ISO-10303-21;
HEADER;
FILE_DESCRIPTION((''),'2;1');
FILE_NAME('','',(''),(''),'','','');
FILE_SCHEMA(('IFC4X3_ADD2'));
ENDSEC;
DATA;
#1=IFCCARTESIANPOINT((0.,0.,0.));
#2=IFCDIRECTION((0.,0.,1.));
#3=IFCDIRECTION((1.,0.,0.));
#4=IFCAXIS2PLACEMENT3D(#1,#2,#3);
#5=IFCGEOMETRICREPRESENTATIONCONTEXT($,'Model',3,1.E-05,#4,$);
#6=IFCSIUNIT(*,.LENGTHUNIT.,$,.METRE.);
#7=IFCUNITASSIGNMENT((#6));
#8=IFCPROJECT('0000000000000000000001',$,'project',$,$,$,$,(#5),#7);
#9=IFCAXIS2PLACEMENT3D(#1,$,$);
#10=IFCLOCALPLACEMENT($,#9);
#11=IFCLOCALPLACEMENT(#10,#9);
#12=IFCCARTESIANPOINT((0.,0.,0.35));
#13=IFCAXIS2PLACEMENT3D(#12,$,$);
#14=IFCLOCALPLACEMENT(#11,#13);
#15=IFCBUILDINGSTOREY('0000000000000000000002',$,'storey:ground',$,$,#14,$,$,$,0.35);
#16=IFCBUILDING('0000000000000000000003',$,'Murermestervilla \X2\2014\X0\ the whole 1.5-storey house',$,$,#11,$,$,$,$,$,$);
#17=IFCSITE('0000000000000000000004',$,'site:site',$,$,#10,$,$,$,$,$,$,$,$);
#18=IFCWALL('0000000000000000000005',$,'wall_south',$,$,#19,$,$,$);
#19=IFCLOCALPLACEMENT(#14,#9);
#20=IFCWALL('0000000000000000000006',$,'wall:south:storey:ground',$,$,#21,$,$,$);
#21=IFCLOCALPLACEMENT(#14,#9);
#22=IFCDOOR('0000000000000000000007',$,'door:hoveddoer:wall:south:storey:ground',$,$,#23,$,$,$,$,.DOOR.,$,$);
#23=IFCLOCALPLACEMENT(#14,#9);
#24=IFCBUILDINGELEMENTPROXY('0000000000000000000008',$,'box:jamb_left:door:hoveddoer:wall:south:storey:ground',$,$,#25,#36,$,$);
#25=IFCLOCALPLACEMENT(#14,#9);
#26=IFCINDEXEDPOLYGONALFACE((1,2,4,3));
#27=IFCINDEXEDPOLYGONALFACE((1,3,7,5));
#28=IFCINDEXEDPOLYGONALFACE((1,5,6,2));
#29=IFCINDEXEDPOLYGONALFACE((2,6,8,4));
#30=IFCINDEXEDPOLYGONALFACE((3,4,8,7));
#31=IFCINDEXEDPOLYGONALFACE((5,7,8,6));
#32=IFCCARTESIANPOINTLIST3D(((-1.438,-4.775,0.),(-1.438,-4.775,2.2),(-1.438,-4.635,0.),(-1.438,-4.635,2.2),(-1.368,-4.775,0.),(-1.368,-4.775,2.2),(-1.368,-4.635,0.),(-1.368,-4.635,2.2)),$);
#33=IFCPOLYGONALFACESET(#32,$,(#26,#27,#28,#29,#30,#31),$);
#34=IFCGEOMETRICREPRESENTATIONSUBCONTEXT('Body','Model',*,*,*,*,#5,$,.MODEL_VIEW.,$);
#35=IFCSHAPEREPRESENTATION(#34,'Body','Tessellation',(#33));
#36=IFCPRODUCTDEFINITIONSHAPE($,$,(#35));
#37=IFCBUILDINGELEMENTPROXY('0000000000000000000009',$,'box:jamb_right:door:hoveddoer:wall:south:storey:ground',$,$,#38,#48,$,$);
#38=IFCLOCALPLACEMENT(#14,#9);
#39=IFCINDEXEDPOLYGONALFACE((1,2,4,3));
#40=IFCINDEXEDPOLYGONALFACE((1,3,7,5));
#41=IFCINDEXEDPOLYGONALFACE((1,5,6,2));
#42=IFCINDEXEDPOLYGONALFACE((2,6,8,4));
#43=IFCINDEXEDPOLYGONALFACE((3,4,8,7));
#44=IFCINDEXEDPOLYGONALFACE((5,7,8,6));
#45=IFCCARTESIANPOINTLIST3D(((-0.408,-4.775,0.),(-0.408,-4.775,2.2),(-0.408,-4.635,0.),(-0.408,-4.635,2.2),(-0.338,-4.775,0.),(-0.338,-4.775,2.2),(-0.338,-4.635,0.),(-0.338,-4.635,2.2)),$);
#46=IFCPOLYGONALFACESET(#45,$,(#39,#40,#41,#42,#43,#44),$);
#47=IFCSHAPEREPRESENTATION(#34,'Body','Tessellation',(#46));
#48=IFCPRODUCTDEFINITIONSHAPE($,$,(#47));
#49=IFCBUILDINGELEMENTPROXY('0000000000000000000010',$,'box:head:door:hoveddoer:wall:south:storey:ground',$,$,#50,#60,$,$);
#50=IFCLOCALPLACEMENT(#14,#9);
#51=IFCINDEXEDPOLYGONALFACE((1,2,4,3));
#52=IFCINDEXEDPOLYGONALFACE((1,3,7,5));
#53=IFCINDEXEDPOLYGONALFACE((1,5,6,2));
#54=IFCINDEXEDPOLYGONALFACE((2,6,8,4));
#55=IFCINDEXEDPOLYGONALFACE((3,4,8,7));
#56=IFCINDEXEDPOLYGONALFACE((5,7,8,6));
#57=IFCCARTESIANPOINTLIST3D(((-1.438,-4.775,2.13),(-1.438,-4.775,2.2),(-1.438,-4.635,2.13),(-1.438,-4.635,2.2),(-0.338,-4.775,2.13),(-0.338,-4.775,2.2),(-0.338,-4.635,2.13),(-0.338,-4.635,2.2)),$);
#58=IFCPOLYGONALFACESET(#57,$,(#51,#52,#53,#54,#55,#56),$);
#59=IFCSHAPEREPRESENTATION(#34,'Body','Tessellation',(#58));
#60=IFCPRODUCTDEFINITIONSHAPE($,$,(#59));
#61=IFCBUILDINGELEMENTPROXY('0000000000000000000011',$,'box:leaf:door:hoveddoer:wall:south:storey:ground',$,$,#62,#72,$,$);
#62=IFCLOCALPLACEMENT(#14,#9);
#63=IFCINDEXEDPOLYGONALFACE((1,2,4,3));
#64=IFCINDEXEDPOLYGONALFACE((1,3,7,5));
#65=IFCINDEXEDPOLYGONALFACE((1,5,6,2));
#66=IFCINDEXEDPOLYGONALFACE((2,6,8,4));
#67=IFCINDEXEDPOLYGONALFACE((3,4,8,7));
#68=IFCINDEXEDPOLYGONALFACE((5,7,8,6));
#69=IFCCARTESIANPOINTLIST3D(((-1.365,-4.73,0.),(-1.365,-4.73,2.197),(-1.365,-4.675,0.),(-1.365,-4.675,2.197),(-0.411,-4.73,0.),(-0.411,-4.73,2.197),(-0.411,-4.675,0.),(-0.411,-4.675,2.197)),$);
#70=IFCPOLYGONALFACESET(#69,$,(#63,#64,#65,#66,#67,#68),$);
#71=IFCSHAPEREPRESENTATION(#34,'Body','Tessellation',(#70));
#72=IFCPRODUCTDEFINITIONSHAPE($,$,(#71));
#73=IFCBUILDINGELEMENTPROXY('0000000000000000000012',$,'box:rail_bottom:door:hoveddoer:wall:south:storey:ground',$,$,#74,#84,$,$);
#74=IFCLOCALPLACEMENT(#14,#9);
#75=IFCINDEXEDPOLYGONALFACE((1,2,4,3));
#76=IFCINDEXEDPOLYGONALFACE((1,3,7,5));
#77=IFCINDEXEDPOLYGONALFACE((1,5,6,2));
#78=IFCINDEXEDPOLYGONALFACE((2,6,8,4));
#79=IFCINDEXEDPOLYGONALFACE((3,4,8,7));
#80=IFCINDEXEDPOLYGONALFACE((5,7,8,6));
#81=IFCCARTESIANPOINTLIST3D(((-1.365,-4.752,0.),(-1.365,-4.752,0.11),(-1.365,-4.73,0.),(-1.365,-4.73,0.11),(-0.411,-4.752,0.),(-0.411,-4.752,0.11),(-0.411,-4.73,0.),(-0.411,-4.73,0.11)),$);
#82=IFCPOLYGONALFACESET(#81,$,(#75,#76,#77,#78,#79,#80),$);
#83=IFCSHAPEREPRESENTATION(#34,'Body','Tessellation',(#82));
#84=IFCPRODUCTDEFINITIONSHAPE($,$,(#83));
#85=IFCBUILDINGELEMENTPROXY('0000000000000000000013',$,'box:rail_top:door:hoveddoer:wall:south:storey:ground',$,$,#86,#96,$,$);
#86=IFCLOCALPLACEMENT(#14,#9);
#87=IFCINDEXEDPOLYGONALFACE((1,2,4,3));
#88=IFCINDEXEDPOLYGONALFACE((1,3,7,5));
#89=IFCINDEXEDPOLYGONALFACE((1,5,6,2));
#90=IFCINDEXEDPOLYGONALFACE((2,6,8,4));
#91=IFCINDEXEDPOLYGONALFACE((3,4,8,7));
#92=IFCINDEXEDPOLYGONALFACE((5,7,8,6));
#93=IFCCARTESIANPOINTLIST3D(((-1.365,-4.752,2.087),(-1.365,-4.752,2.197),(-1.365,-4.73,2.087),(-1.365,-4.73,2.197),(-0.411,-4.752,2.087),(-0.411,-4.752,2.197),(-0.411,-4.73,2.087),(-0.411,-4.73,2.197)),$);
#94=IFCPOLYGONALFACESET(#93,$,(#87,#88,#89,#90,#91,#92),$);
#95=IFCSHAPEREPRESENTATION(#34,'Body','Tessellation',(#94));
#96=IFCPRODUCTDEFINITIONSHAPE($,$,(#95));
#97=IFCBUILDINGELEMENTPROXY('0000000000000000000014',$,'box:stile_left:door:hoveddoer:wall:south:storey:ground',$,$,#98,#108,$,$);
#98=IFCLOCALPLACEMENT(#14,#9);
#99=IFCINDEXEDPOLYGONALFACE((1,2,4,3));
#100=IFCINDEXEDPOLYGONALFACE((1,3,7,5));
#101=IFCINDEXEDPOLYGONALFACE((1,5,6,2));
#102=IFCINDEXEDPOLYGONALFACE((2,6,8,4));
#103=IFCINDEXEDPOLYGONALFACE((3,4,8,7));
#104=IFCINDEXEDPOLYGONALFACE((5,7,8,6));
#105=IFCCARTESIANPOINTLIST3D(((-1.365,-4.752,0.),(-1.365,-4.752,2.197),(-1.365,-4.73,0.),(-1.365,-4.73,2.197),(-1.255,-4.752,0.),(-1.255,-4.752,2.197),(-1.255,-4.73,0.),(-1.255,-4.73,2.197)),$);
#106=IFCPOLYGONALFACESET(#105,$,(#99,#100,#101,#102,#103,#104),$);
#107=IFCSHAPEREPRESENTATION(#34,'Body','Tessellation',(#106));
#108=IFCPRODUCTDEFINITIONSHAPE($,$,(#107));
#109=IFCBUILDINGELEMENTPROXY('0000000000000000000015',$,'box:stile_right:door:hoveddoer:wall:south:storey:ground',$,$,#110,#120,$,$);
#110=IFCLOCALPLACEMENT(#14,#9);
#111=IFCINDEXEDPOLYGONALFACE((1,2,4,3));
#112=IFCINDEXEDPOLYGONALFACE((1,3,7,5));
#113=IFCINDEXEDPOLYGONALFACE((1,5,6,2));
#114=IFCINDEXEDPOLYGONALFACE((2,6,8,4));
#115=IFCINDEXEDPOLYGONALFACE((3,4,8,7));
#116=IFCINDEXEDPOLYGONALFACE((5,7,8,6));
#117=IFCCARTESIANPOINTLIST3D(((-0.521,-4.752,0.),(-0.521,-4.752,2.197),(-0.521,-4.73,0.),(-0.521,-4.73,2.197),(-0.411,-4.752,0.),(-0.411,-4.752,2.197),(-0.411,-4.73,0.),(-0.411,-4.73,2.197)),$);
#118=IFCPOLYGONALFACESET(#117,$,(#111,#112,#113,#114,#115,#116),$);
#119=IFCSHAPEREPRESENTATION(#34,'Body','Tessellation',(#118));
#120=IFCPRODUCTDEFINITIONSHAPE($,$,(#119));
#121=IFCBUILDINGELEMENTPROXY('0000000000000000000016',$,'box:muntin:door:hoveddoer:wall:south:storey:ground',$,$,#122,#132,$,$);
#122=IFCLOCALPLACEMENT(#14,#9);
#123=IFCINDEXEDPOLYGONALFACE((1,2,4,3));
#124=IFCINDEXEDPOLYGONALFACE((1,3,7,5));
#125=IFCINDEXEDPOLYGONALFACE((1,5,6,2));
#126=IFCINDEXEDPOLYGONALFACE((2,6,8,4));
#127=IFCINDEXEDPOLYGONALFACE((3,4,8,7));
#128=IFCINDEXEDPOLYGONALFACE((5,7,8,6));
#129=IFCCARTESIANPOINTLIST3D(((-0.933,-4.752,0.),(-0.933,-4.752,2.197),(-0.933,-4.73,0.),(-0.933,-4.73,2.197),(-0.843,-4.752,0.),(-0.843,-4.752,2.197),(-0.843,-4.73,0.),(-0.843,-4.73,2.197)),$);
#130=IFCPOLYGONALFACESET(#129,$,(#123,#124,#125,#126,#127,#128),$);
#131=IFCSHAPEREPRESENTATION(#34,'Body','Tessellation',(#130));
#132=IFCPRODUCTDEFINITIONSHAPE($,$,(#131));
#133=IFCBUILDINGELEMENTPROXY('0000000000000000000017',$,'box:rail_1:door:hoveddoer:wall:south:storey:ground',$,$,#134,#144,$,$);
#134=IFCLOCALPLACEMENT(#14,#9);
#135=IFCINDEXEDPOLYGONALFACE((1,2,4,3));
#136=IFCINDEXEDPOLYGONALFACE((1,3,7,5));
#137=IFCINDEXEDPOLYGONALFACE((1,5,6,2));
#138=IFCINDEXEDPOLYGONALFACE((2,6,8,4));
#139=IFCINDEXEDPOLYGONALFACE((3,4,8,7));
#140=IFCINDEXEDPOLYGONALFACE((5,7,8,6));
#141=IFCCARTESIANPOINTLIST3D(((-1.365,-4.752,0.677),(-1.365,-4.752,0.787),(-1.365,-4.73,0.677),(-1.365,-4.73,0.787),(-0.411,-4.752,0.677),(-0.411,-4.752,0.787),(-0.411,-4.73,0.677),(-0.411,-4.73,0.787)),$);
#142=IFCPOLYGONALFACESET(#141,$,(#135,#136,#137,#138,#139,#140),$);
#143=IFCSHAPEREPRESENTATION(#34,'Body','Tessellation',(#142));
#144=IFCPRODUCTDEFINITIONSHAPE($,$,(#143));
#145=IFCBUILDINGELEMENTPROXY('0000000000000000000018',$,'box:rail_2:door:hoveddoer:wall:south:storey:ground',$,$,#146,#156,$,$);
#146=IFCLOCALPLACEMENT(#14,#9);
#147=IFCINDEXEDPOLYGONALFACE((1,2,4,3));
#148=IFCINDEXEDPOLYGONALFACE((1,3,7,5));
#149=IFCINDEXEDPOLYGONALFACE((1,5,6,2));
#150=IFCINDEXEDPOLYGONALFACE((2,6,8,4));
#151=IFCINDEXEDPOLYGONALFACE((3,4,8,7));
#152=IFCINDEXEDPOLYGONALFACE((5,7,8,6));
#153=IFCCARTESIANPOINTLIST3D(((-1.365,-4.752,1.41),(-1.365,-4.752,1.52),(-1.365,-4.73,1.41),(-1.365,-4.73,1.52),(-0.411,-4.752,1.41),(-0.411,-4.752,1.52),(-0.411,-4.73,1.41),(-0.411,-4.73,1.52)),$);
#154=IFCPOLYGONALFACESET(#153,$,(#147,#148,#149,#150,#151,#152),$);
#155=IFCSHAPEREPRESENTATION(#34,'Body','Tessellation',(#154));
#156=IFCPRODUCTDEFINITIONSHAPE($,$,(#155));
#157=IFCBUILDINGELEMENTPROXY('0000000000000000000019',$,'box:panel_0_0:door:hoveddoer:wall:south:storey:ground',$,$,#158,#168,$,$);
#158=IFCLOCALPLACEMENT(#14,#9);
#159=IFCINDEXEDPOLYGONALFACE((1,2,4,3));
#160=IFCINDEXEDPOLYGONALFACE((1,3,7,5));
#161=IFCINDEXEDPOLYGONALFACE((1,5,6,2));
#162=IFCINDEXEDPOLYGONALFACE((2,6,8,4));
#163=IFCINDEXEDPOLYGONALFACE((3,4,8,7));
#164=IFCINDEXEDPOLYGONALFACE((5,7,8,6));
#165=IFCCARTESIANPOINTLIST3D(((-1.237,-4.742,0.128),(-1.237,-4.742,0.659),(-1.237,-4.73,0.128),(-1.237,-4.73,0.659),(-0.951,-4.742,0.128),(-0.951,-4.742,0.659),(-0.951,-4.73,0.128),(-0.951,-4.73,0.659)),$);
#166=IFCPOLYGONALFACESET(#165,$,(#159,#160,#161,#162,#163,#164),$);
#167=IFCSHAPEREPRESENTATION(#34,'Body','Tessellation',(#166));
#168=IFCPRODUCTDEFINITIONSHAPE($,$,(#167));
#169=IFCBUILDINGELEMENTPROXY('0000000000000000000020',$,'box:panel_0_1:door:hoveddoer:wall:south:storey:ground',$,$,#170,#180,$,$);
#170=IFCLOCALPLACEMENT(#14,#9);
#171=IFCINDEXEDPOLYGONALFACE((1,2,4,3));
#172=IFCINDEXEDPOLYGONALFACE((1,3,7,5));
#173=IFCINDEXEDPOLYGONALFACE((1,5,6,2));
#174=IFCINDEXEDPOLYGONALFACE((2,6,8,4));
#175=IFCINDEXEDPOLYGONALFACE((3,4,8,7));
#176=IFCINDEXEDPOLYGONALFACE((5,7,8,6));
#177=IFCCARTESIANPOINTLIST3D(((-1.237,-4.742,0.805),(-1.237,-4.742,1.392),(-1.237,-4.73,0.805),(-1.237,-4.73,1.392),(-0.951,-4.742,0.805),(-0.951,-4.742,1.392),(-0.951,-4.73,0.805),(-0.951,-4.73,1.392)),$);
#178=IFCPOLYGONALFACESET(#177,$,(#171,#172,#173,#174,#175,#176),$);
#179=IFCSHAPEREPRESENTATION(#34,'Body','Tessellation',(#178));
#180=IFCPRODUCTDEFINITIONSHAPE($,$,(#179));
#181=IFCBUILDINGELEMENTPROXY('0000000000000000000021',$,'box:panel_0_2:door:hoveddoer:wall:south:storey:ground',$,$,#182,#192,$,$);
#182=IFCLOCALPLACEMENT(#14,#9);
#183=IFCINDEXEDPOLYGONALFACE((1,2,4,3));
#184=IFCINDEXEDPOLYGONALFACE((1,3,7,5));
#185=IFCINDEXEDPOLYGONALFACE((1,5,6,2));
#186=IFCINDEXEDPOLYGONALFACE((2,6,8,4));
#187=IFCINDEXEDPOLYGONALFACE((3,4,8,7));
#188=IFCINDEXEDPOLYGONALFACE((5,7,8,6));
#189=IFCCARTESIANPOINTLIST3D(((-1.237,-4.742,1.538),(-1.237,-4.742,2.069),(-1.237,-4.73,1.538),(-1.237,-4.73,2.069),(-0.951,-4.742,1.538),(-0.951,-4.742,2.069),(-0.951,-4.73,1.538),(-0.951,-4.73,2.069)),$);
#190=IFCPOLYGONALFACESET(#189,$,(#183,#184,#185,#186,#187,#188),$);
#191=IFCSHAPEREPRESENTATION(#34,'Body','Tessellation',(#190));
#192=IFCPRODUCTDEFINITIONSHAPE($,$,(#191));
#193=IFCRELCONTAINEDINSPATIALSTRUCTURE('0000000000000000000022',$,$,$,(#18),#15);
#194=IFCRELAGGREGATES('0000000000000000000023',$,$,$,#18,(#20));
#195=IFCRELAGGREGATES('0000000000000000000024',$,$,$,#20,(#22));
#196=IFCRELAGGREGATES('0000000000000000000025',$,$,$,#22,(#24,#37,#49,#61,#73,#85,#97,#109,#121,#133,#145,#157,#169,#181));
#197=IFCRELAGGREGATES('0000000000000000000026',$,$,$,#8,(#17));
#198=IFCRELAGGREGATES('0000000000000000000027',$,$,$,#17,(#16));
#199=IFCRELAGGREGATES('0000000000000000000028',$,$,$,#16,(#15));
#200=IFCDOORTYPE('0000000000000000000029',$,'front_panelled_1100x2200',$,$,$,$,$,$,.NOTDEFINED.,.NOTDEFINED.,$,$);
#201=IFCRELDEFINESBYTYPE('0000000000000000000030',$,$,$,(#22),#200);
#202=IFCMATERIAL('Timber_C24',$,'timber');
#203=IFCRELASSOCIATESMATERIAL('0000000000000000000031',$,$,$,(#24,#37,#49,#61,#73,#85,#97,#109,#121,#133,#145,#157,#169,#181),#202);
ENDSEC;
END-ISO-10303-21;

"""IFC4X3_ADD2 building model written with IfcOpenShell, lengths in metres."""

from ifc_helpers import new_model, si_unit, frame, origin, origin_with_axes, place, context, subcontext, project, spatial, rectangle, extrude, source, transform, mapped, material, type_object, element, aggregate, save


model = new_model("IFC4X3_ADD2")

# Units and contexts
model_context = context("Model", 3, precision=1e-05, world=origin_with_axes())
body_context = subcontext(model_context, "Body", "Model", "MODEL_VIEW")
ifc_project = project(units=[si_unit("LENGTHUNIT", "METRE")], contexts=[model_context])

# Site, building, storey
placement = place(None, origin())
site = spatial("IfcSite", under=ifc_project, at=placement, Name="site:site")
building_placement = place(placement, origin())
building = spatial("IfcBuilding", under=site, at=building_placement, Name="Murermestervilla — the whole 1.5-storey house")
storey_placement = place(building_placement, frame((0.0, 0.0, 0.35)))
storey = spatial("IfcBuildingStorey", under=building, at=storey_placement, Name="storey:ground", Elevation=0.35)

# Walls, door, building element proxies
wall_1_placement = place(storey_placement, origin())
wall_1 = element("IfcWall", 1, at=wall_1_placement, inside=storey, Name="wall_south")
wall_2_placement = place(wall_1_placement, frame((0.0, 0.0, -0.35)))
wall_2 = element("IfcWall", 2, at=wall_2_placement, Name="wall:south:storey:ground")
aggregate(wall_1, [wall_2])
door_type = type_object("IfcDoorType", Name="front_panelled_1100x2200", OperationType="NOTDEFINED", PredefinedType="NOTDEFINED")
door_placement = place(None, frame((-0.888, -4.828, 0.35)))
door = element("IfcDoor", 3, at=door_placement, type_object=door_type, Name="door:hoveddoer:wall:south:storey:ground", PredefinedType="DOOR")
aggregate(wall_2, [door])
ifc_material_1 = material(Name="Timber_C24", Category="timber")
shared_shape_1 = source(origin(), body_context, "Body", "SweptSolid", [
    extrude(rectangle(XDim=0.07, YDim=0.14), frame((0.0, 0.0, -1.1)), (0.0, 0.0, 1.0), 2.2),
])
proxy_1_placement = place(None, frame((-1.403, -4.705, 1.45)))
proxy_1 = element("IfcBuildingElementProxy", 4, at=proxy_1_placement, material=ifc_material_1, Name="box:jamb_left:door:hoveddoer:wall:south:storey:ground", context=body_context, shape_type="MappedRepresentation", body=[
    mapped(shared_shape_1, transform((0.0, 0.0, 0.0))),
])
shared_shape_2 = source(origin(), body_context, "Body", "SweptSolid", [
    extrude(rectangle(XDim=0.07, YDim=0.14), frame((0.0, 0.0, -1.1)), (0.0, 0.0, 1.0), 2.2),
])
proxy_2_placement = place(None, frame((-0.373, -4.705, 1.45)))
proxy_2 = element("IfcBuildingElementProxy", 5, at=proxy_2_placement, material=ifc_material_1, Name="box:jamb_right:door:hoveddoer:wall:south:storey:ground", context=body_context, shape_type="MappedRepresentation", body=[
    mapped(shared_shape_2, transform((0.0, 0.0, 0.0))),
])
shared_shape_3 = source(origin(), body_context, "Body", "SweptSolid", [
    extrude(rectangle(XDim=1.1, YDim=0.14), frame((0.0, 0.0, -0.035)), (0.0, 0.0, 1.0), 0.07),
])
proxy_3_placement = place(None, frame((-0.888, -4.705, 2.515)))
proxy_3 = element("IfcBuildingElementProxy", 6, at=proxy_3_placement, material=ifc_material_1, Name="box:head:door:hoveddoer:wall:south:storey:ground", context=body_context, shape_type="MappedRepresentation", body=[
    mapped(shared_shape_3, transform((0.0, 0.0, 0.0))),
])
shared_shape_4 = source(origin(), body_context, "Body", "SweptSolid", [
    extrude(rectangle(XDim=0.954, YDim=0.055), frame((0.0, 0.0, -1.0985)), (0.0, 0.0, 1.0), 2.197),
])
proxy_4_placement = place(None, frame((-0.888, -4.7025, 1.4485)))
proxy_4 = element("IfcBuildingElementProxy", 7, at=proxy_4_placement, material=ifc_material_1, Name="box:leaf:door:hoveddoer:wall:south:storey:ground", context=body_context, shape_type="MappedRepresentation", body=[
    mapped(shared_shape_4, transform((0.0, 0.0, 0.0))),
])
shared_shape_5 = source(origin(), body_context, "Body", "SweptSolid", [
    extrude(rectangle(XDim=0.954, YDim=0.022), frame((0.0, 0.0, -0.055)), (0.0, 0.0, 1.0), 0.11),
])
proxy_5_placement = place(None, frame((-0.888, -4.741, 0.405)))
proxy_5 = element("IfcBuildingElementProxy", 8, at=proxy_5_placement, material=ifc_material_1, Name="box:rail_bottom:door:hoveddoer:wall:south:storey:ground", context=body_context, shape_type="MappedRepresentation", body=[
    mapped(shared_shape_5, transform((0.0, 0.0, 0.0))),
])
shared_shape_6 = source(origin(), body_context, "Body", "SweptSolid", [
    extrude(rectangle(XDim=0.954, YDim=0.022), frame((0.0, 0.0, -0.055)), (0.0, 0.0, 1.0), 0.11),
])
proxy_6_placement = place(None, frame((-0.888, -4.741, 2.492)))
proxy_6 = element("IfcBuildingElementProxy", 9, at=proxy_6_placement, material=ifc_material_1, Name="box:rail_top:door:hoveddoer:wall:south:storey:ground", context=body_context, shape_type="MappedRepresentation", body=[
    mapped(shared_shape_6, transform((0.0, 0.0, 0.0))),
])
shared_shape_7 = source(origin(), body_context, "Body", "SweptSolid", [
    extrude(rectangle(XDim=0.11, YDim=0.022), frame((0.0, 0.0, -1.0985)), (0.0, 0.0, 1.0), 2.197),
])
proxy_7_placement = place(None, frame((-1.31, -4.741, 1.4485)))
proxy_7 = element("IfcBuildingElementProxy", 10, at=proxy_7_placement, material=ifc_material_1, Name="box:stile_left:door:hoveddoer:wall:south:storey:ground", context=body_context, shape_type="MappedRepresentation", body=[
    mapped(shared_shape_7, transform((0.0, 0.0, 0.0))),
])
shared_shape_8 = source(origin(), body_context, "Body", "SweptSolid", [
    extrude(rectangle(XDim=0.11, YDim=0.022), frame((0.0, 0.0, -1.0985)), (0.0, 0.0, 1.0), 2.197),
])
proxy_8_placement = place(None, frame((-0.466, -4.741, 1.4485)))
proxy_8 = element("IfcBuildingElementProxy", 11, at=proxy_8_placement, material=ifc_material_1, Name="box:stile_right:door:hoveddoer:wall:south:storey:ground", context=body_context, shape_type="MappedRepresentation", body=[
    mapped(shared_shape_8, transform((0.0, 0.0, 0.0))),
])
shared_shape_9 = source(origin(), body_context, "Body", "SweptSolid", [
    extrude(rectangle(XDim=0.09, YDim=0.022), frame((0.0, 0.0, -1.0985)), (0.0, 0.0, 1.0), 2.197),
])
proxy_9_placement = place(None, frame((-0.888, -4.741, 1.4485)))
proxy_9 = element("IfcBuildingElementProxy", 12, at=proxy_9_placement, material=ifc_material_1, Name="box:muntin:door:hoveddoer:wall:south:storey:ground", context=body_context, shape_type="MappedRepresentation", body=[
    mapped(shared_shape_9, transform((0.0, 0.0, 0.0))),
])
shared_shape_10 = source(origin(), body_context, "Body", "SweptSolid", [
    extrude(rectangle(XDim=0.954, YDim=0.022), frame((0.0, 0.0, -0.055)), (0.0, 0.0, 1.0), 0.11),
])
proxy_10_placement = place(None, frame((-0.888, -4.741, 1.082)))
proxy_10 = element("IfcBuildingElementProxy", 13, at=proxy_10_placement, material=ifc_material_1, Name="box:rail_1:door:hoveddoer:wall:south:storey:ground", context=body_context, shape_type="MappedRepresentation", body=[
    mapped(shared_shape_10, transform((0.0, 0.0, 0.0))),
])
shared_shape_11 = source(origin(), body_context, "Body", "SweptSolid", [
    extrude(rectangle(XDim=0.954, YDim=0.022), frame((0.0, 0.0, -0.055)), (0.0, 0.0, 1.0), 0.11),
])
proxy_11_placement = place(None, frame((-0.888, -4.741, 1.815)))
proxy_11 = element("IfcBuildingElementProxy", 14, at=proxy_11_placement, material=ifc_material_1, Name="box:rail_2:door:hoveddoer:wall:south:storey:ground", context=body_context, shape_type="MappedRepresentation", body=[
    mapped(shared_shape_11, transform((0.0, 0.0, 0.0))),
])
shared_shape_12 = source(origin(), body_context, "Body", "SweptSolid", [
    extrude(rectangle(XDim=0.286, YDim=0.012), frame((0.0, 0.0, -0.2655)), (0.0, 0.0, 1.0), 0.531),
])
proxy_12_placement = place(None, frame((-1.094, -4.736, 0.7435)))
proxy_12 = element("IfcBuildingElementProxy", 15, at=proxy_12_placement, material=ifc_material_1, Name="box:panel_0_0:door:hoveddoer:wall:south:storey:ground", context=body_context, shape_type="MappedRepresentation", body=[
    mapped(shared_shape_12, transform((0.0, 0.0, 0.0))),
])
shared_shape_13 = source(origin(), body_context, "Body", "SweptSolid", [
    extrude(rectangle(XDim=0.286, YDim=0.012), frame((0.0, 0.0, -0.2935)), (0.0, 0.0, 1.0), 0.587),
])
proxy_13_placement = place(None, frame((-1.094, -4.736, 1.4485)))
proxy_13 = element("IfcBuildingElementProxy", 16, at=proxy_13_placement, material=ifc_material_1, Name="box:panel_0_1:door:hoveddoer:wall:south:storey:ground", context=body_context, shape_type="MappedRepresentation", body=[
    mapped(shared_shape_13, transform((0.0, 0.0, 0.0))),
])
shared_shape_14 = source(origin(), body_context, "Body", "SweptSolid", [
    extrude(rectangle(XDim=0.286, YDim=0.012), frame((0.0, 0.0, -0.2655)), (0.0, 0.0, 1.0), 0.531),
])
proxy_14_placement = place(None, frame((-1.094, -4.736, 2.1535)))
proxy_14 = element("IfcBuildingElementProxy", 17, at=proxy_14_placement, material=ifc_material_1, Name="box:panel_0_2:door:hoveddoer:wall:south:storey:ground", context=body_context, shape_type="MappedRepresentation", body=[
    mapped(shared_shape_14, transform((0.0, 0.0, 0.0))),
])
aggregate(door, [proxy_1, proxy_2, proxy_3, proxy_4, proxy_5, proxy_6, proxy_7, proxy_8, proxy_9, proxy_10, proxy_11, proxy_12, proxy_13, proxy_14])

save(model, "model.ifc")
